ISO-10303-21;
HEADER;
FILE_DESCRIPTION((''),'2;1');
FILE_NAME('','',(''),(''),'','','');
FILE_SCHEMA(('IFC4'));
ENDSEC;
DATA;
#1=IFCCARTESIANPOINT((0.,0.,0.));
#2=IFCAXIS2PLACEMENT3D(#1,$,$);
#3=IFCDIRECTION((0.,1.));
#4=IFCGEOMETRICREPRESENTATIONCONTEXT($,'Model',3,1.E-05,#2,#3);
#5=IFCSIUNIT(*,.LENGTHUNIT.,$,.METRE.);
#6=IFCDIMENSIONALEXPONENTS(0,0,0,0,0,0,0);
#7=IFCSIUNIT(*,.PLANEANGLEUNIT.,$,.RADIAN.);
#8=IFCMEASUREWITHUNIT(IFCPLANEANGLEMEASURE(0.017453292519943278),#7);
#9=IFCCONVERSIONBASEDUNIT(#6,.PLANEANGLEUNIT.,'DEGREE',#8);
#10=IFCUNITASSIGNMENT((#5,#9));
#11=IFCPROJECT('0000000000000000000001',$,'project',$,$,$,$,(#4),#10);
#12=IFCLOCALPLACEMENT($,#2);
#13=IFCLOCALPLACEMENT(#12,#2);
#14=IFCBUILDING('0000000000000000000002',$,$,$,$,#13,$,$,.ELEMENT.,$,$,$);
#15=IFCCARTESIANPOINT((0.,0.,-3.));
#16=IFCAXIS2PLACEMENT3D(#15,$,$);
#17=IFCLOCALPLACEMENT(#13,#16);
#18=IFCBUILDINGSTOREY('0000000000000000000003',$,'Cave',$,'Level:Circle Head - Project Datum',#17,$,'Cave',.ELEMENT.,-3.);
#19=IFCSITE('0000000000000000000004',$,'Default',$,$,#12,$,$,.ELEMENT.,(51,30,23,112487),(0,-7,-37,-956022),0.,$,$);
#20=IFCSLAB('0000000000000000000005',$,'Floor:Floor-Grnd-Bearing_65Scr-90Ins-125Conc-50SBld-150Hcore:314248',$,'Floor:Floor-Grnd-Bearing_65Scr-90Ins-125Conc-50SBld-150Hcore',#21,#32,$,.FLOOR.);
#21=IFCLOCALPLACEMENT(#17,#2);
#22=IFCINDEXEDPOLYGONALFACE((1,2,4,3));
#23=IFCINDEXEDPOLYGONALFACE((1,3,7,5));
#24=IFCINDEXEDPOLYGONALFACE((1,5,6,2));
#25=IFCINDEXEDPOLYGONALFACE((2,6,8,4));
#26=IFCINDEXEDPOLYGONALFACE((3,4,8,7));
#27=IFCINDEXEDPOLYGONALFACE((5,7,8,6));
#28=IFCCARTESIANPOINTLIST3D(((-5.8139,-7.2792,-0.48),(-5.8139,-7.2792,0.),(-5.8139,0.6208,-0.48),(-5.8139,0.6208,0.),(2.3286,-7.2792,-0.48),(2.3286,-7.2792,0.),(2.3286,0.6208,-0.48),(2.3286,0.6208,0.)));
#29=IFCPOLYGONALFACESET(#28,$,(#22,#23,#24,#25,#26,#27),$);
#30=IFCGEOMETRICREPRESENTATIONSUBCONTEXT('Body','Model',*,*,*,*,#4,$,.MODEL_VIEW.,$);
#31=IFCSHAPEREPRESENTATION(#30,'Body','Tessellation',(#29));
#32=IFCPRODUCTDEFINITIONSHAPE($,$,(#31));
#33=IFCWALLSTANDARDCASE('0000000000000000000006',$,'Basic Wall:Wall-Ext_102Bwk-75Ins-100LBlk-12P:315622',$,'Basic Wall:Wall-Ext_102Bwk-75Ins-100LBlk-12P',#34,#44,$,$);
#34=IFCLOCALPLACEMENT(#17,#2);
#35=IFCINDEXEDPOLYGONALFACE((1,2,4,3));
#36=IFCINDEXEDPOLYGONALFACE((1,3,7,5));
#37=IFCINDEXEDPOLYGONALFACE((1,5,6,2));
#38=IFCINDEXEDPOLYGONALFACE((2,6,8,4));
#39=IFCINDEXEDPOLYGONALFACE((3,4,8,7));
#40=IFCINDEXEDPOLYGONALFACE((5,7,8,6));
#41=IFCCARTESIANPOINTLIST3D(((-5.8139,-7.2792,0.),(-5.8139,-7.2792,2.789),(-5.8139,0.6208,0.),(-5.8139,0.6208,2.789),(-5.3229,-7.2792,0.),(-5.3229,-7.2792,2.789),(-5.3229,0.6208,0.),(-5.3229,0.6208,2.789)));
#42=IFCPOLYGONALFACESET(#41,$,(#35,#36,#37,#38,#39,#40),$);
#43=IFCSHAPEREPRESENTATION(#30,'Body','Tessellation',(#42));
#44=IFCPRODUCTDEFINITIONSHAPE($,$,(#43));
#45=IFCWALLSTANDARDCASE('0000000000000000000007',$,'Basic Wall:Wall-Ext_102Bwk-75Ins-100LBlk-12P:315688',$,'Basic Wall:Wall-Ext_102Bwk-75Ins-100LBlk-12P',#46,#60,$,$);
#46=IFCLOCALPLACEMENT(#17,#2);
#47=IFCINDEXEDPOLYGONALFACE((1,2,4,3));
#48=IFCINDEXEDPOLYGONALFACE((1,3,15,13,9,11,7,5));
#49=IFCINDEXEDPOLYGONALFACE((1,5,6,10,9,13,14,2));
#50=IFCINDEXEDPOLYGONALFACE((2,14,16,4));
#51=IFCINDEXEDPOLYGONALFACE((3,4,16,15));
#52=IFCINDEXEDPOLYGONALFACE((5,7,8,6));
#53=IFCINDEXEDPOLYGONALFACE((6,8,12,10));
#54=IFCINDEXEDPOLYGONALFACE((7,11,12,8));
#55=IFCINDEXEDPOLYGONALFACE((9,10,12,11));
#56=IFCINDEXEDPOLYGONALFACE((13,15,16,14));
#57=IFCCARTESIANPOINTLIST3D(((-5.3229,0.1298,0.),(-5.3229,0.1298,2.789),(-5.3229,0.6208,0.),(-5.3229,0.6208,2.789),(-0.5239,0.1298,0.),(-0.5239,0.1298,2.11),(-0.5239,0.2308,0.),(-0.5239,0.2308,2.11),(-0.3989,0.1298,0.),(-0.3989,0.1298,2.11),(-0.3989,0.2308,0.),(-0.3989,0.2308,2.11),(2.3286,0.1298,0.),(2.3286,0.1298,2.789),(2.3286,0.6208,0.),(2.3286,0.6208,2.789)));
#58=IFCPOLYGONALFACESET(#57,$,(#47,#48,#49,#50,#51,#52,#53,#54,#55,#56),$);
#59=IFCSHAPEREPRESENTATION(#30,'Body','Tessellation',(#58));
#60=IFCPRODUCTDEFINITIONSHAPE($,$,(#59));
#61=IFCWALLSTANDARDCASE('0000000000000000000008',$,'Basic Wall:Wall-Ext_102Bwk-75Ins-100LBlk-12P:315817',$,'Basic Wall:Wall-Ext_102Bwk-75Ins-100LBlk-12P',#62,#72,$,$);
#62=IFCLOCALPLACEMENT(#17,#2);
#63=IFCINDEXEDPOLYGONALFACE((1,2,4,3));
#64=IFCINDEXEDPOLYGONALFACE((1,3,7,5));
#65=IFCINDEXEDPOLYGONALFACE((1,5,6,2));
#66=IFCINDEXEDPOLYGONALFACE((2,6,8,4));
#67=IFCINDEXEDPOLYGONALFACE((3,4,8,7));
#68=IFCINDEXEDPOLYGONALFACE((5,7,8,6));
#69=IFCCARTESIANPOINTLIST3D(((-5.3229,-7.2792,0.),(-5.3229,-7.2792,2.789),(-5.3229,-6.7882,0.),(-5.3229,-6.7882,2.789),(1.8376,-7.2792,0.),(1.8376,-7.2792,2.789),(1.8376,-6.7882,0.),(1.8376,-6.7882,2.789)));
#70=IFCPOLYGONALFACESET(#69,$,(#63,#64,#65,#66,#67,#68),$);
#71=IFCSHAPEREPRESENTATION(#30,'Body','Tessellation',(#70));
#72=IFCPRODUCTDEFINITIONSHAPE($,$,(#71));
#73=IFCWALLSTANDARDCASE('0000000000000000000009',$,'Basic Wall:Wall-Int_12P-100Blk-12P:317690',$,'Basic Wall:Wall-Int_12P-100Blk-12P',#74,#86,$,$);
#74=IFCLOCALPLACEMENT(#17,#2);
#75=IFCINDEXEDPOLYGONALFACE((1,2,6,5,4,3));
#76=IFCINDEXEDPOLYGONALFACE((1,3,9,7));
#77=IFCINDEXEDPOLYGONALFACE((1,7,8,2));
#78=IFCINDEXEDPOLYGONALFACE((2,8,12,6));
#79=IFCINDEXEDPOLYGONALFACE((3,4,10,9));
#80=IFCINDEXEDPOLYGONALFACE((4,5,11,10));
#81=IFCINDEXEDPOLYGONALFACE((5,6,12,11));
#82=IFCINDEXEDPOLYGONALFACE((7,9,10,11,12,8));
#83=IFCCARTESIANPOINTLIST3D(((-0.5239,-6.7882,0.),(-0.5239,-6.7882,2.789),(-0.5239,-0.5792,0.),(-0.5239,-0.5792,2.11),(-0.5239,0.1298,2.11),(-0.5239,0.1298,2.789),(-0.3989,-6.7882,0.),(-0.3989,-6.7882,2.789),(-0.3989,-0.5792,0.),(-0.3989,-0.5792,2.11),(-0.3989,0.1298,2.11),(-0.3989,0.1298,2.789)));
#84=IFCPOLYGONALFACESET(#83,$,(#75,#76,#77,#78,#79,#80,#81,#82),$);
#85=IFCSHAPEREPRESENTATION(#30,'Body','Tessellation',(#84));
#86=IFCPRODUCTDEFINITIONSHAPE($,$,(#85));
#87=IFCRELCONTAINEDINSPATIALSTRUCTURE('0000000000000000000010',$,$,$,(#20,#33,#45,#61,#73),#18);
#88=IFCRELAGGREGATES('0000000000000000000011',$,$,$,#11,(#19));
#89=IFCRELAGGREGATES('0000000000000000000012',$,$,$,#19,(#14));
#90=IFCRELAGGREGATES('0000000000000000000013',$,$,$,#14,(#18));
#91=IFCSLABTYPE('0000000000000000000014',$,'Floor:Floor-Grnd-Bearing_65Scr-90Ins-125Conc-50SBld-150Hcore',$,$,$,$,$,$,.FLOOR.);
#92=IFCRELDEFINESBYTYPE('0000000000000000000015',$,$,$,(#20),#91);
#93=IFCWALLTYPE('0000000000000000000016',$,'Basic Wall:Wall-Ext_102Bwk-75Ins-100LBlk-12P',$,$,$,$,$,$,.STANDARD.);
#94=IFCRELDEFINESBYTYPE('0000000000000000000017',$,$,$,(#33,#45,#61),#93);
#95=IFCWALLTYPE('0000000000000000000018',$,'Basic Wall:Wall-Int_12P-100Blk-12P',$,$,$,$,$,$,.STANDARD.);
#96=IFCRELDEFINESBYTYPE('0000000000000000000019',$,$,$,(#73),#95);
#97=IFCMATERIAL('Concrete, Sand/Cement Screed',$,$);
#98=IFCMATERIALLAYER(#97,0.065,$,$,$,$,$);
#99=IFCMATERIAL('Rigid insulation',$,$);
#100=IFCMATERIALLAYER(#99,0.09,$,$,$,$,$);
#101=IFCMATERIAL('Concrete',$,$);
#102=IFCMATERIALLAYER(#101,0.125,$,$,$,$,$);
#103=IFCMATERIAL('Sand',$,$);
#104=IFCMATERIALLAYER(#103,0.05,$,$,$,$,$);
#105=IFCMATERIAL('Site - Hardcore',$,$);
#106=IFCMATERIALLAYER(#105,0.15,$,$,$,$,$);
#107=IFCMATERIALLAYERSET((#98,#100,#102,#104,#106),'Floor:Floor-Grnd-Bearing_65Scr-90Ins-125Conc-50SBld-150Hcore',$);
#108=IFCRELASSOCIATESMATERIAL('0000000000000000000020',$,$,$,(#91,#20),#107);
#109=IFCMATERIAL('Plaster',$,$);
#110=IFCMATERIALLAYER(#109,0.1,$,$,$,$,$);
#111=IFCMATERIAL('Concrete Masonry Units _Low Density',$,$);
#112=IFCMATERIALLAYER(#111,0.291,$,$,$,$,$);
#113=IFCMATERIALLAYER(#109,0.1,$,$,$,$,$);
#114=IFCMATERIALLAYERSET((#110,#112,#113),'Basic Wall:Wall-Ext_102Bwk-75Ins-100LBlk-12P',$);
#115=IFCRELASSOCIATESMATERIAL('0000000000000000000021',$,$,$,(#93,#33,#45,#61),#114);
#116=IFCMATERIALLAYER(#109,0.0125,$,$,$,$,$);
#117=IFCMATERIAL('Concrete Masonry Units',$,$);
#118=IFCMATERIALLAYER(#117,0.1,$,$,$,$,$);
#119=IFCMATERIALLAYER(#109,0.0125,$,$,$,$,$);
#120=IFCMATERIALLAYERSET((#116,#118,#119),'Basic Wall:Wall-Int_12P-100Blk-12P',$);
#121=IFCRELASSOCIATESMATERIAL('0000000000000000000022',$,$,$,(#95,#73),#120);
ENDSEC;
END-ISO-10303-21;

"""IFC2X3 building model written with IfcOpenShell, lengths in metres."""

from ifc_helpers import new_model, entity, si_unit, converted_unit, direction, frame, frame_2d, origin, origin_2d_with_axis, place, context, subcontext, project, spatial, polyline, rectangle, extrude, clip, bounded_halfspace, material, layer, layer_set, layer_usage, type_object, element, save


model = new_model("IFC2X3")

# Units and contexts
model_context = context("Model", 3, precision=1e-05, world=origin(), true_north=direction((0.0, 1.0)))
body_context = subcontext(model_context, "Body", "Model", "MODEL_VIEW")
ifc_project = project(units=[si_unit("LENGTHUNIT", "METRE"), converted_unit("PLANEANGLEUNIT", "DEGREE", entity("IfcPlaneAngleMeasure", 0.017453292519943278), si_unit("PLANEANGLEUNIT", "RADIAN"), dimensions=[0, 0, 0, 0, 0, 0, 0])], contexts=[model_context])

# Site, building, storey
site_placement = place(None, origin())
site = spatial("IfcSite", under=ifc_project, at=site_placement, Name="Default", CompositionType="ELEMENT", RefLatitude=(51, 30, 23, 112487), RefLongitude=(0, -7, -37, -956022), RefElevation=0.0)
building_placement = place(site_placement, origin())
building = spatial("IfcBuilding", under=site, at=building_placement, CompositionType="ELEMENT")
storey_placement = place(building_placement, frame((0.0, 0.0, -3.0)))
storey = spatial("IfcBuildingStorey", under=building, at=storey_placement, Name="Cave", ObjectType="Level:Circle Head - Project Datum", LongName="Cave", CompositionType="ELEMENT", Elevation=-3.0)

# Slab
ifc_material_1 = material(Name="Concrete, Sand/Cement Screed")
ifc_layer_1 = layer(ifc_material_1, 0.065)
ifc_material_2 = material(Name="Rigid insulation")
ifc_layer_2 = layer(ifc_material_2, 0.09)
ifc_material_3 = material(Name="Concrete")
ifc_layer_3 = layer(ifc_material_3, 0.125)
ifc_material_4 = material(Name="Sand")
ifc_layer_4 = layer(ifc_material_4, 0.05)
ifc_material_5 = material(Name="Site - Hardcore")
ifc_layer_5 = layer(ifc_material_5, 0.15)
ifc_layer_set_1 = layer_set([ifc_layer_1, ifc_layer_2, ifc_layer_3, ifc_layer_4, ifc_layer_5], Name="Floor:Floor-Grnd-Bearing_65Scr-90Ins-125Conc-50SBld-150Hcore")
ifc_layer_usage_1 = layer_usage(ifc_layer_set_1, "AXIS3", "POSITIVE", 0.0)
slab_type = type_object("IfcSlabType", Name="Floor:Floor-Grnd-Bearing_65Scr-90Ins-125Conc-50SBld-150Hcore", PredefinedType="FLOOR", material=ifc_layer_set_1)
slab_placement = place(storey_placement, origin())
element("IfcSlab", 1, at=slab_placement, inside=storey, type_object=slab_type, material=ifc_layer_usage_1, Name="Floor:Floor-Grnd-Bearing_65Scr-90Ins-125Conc-50SBld-150Hcore:314248", ObjectType="Floor:Floor-Grnd-Bearing_65Scr-90Ins-125Conc-50SBld-150Hcore", PredefinedType="FLOOR", context=body_context, shape_type="SweptSolid", body=[
    extrude(rectangle(XDim=7.9, YDim=8.1425, at=origin_2d_with_axis()), frame((-1.7426, -3.3292, 0.0), z_axis=(0.0, 0.0, -1.0), x_axis=(0.0, 1.0, 0.0)), (0.0, 0.0, 1.0), 0.48),
])

# Wall
ifc_material_6 = material(Name="Plaster")
ifc_layer_6 = layer(ifc_material_6, 0.1)
ifc_material_7 = material(Name="Concrete Masonry Units _Low Density")
ifc_layer_7 = layer(ifc_material_7, 0.291)
ifc_layer_8 = layer(ifc_material_6, 0.1)
ifc_layer_set_2 = layer_set([ifc_layer_6, ifc_layer_7, ifc_layer_8], Name="Basic Wall:Wall-Ext_102Bwk-75Ins-100LBlk-12P")
ifc_layer_usage_2 = layer_usage(ifc_layer_set_2, "AXIS2", "NEGATIVE", 0.2455)
wall_type_1 = type_object("IfcWallType", Name="Basic Wall:Wall-Ext_102Bwk-75Ins-100LBlk-12P", PredefinedType="STANDARD", material=ifc_layer_set_2)
wall_1_placement = place(storey_placement, frame((-5.5684, -7.2792, 0.0), z_axis=(0.0, 0.0, 1.0), x_axis=(0.0, 1.0, 0.0)))
element("IfcWallStandardCase", 2, at=wall_1_placement, inside=storey, type_object=wall_type_1, material=ifc_layer_usage_2, Name="Basic Wall:Wall-Ext_102Bwk-75Ins-100LBlk-12P:315622", ObjectType="Basic Wall:Wall-Ext_102Bwk-75Ins-100LBlk-12P", context=body_context, shape_type="Clipping", body=[
    clip(extrude(rectangle(XDim=7.9, YDim=0.491, at=frame_2d((3.95, 0.0), x_axis=(-1.0, 0.0))), origin(), (0.0, 0.0, 1.0), 2.789), bounded_halfspace(frame((0.0, -0.2455, 2.789), z_axis=(0.0, 0.0, -1.0), x_axis=(0.0, 1.0, 0.0)), True, frame((0.0, -0.2455, 2.789), z_axis=(0.0, 0.0, -1.0), x_axis=(0.0, 1.0, 0.0)), polyline([(0.0, 0.0), (0.491, 0.0), (0.491, 7.9), (0.0, 7.9), (0.0, 7.409), (0.0, 0.491), (0.0, 0.0)]))),
])

# Wall, opening
wall_2_placement = place(storey_placement, frame((-5.3229, 0.3753, 0.0)))
wall_2 = element("IfcWallStandardCase", 3, at=wall_2_placement, inside=storey, type_object=wall_type_1, material=ifc_layer_usage_2, Name="Basic Wall:Wall-Ext_102Bwk-75Ins-100LBlk-12P:315688", ObjectType="Basic Wall:Wall-Ext_102Bwk-75Ins-100LBlk-12P", context=body_context, shape_type="Clipping", body=[
    clip(extrude(rectangle(XDim=7.6515, YDim=0.491, at=frame_2d((3.8257, 0.0), x_axis=(-1.0, 0.0))), origin(), (0.0, 0.0, 1.0), 2.789), bounded_halfspace(frame((0.0, -0.2455, 2.789), z_axis=(0.0, 0.0, -1.0), x_axis=(-1.0, 0.0, 0.0)), True, frame((0.0, -0.2455, 2.789), z_axis=(0.0, 0.0, -1.0), x_axis=(-1.0, 0.0, 0.0)), polyline([(0.0, 0.0), (0.0, 0.491), (-7.6515, 0.491), (-7.6515, 0.0), (-7.1605, 0.0), (-4.924, 0.0), (-4.799, 0.0), (0.0, 0.0)]))),
])
opening_1_placement = place(wall_2_placement, origin())
element("IfcOpeningElement", 4, at=opening_1_placement, cuts=wall_2, ObjectType="Opening", context=body_context, shape_type="SweptSolid", body=[
    extrude(rectangle(XDim=2.11, YDim=0.125, at=frame_2d((0.0, 0.0), x_axis=(0.0, 1.0))), frame((4.8615, -0.9545, 1.055), z_axis=(0.0, 1.0, 0.0), x_axis=(-1.0, 0.0, 0.0)), (0.0, 0.0, 1.0), 0.81),
])

# Wall
wall_3_placement = place(storey_placement, frame((1.8376, -7.0337, 0.0), z_axis=(0.0, 0.0, 1.0), x_axis=(-1.0, 0.0, 0.0)))
element("IfcWallStandardCase", 5, at=wall_3_placement, inside=storey, type_object=wall_type_1, material=ifc_layer_usage_2, Name="Basic Wall:Wall-Ext_102Bwk-75Ins-100LBlk-12P:315817", ObjectType="Basic Wall:Wall-Ext_102Bwk-75Ins-100LBlk-12P", context=body_context, shape_type="Clipping", body=[
    clip(extrude(rectangle(XDim=7.1605, YDim=0.491, at=frame_2d((3.5802, 0.0), x_axis=(-1.0, 0.0))), origin(), (0.0, 0.0, 1.0), 2.789), bounded_halfspace(frame((0.0, -0.2455, 2.789), z_axis=(0.0, 0.0, -1.0), x_axis=(1.0, 0.0, 0.0)), True, frame((0.0, -0.2455, 2.789), z_axis=(0.0, 0.0, -1.0), x_axis=(1.0, 0.0, 0.0)), polyline([(0.0, 0.0), (0.0, -0.491), (7.1605, -0.491), (7.1605, 0.0), (2.3615, 0.0), (2.2365, 0.0), (0.0, 0.0)]))),
])

# Wall, opening
ifc_layer_9 = layer(ifc_material_6, 0.0125)
ifc_material_8 = material(Name="Concrete Masonry Units")
ifc_layer_10 = layer(ifc_material_8, 0.1)
ifc_layer_11 = layer(ifc_material_6, 0.0125)
ifc_layer_set_3 = layer_set([ifc_layer_9, ifc_layer_10, ifc_layer_11], Name="Basic Wall:Wall-Int_12P-100Blk-12P")
ifc_layer_usage_3 = layer_usage(ifc_layer_set_3, "AXIS2", "NEGATIVE", 0.0625)
wall_type_2 = type_object("IfcWallType", Name="Basic Wall:Wall-Int_12P-100Blk-12P", PredefinedType="STANDARD", material=ifc_layer_set_3)
wall_4_placement = place(storey_placement, frame((-0.4614, 0.1298, 0.0), z_axis=(0.0, 0.0, 1.0), x_axis=(0.0, -1.0, 0.0)))
wall_4 = element("IfcWallStandardCase", 6, at=wall_4_placement, inside=storey, type_object=wall_type_2, material=ifc_layer_usage_3, Name="Basic Wall:Wall-Int_12P-100Blk-12P:317690", ObjectType="Basic Wall:Wall-Int_12P-100Blk-12P", context=body_context, shape_type="SweptSolid", body=[
    extrude(rectangle(XDim=6.918, YDim=0.125, at=frame_2d((3.459, 0.0), x_axis=(-1.0, 0.0))), origin(), (0.0, 0.0, 1.0), 2.789),
])
opening_2_placement = place(wall_4_placement, frame((0.709, 0.0625, 0.0)))
element("IfcOpeningElement", 7, at=opening_2_placement, cuts=wall_4, ObjectType="Opening", context=body_context, shape_type="SweptSolid", body=[
    extrude(rectangle(XDim=2.11, YDim=0.81, at=frame_2d((1.055, 0.405), x_axis=(1.0, 0.0))), frame((0.0, 0.0, 0.0), z_axis=(0.0, -1.0, 0.0), x_axis=(0.0, 0.0, 1.0)), (0.0, 0.0, 1.0), 0.125),
])

save(model, "model.ifc")
